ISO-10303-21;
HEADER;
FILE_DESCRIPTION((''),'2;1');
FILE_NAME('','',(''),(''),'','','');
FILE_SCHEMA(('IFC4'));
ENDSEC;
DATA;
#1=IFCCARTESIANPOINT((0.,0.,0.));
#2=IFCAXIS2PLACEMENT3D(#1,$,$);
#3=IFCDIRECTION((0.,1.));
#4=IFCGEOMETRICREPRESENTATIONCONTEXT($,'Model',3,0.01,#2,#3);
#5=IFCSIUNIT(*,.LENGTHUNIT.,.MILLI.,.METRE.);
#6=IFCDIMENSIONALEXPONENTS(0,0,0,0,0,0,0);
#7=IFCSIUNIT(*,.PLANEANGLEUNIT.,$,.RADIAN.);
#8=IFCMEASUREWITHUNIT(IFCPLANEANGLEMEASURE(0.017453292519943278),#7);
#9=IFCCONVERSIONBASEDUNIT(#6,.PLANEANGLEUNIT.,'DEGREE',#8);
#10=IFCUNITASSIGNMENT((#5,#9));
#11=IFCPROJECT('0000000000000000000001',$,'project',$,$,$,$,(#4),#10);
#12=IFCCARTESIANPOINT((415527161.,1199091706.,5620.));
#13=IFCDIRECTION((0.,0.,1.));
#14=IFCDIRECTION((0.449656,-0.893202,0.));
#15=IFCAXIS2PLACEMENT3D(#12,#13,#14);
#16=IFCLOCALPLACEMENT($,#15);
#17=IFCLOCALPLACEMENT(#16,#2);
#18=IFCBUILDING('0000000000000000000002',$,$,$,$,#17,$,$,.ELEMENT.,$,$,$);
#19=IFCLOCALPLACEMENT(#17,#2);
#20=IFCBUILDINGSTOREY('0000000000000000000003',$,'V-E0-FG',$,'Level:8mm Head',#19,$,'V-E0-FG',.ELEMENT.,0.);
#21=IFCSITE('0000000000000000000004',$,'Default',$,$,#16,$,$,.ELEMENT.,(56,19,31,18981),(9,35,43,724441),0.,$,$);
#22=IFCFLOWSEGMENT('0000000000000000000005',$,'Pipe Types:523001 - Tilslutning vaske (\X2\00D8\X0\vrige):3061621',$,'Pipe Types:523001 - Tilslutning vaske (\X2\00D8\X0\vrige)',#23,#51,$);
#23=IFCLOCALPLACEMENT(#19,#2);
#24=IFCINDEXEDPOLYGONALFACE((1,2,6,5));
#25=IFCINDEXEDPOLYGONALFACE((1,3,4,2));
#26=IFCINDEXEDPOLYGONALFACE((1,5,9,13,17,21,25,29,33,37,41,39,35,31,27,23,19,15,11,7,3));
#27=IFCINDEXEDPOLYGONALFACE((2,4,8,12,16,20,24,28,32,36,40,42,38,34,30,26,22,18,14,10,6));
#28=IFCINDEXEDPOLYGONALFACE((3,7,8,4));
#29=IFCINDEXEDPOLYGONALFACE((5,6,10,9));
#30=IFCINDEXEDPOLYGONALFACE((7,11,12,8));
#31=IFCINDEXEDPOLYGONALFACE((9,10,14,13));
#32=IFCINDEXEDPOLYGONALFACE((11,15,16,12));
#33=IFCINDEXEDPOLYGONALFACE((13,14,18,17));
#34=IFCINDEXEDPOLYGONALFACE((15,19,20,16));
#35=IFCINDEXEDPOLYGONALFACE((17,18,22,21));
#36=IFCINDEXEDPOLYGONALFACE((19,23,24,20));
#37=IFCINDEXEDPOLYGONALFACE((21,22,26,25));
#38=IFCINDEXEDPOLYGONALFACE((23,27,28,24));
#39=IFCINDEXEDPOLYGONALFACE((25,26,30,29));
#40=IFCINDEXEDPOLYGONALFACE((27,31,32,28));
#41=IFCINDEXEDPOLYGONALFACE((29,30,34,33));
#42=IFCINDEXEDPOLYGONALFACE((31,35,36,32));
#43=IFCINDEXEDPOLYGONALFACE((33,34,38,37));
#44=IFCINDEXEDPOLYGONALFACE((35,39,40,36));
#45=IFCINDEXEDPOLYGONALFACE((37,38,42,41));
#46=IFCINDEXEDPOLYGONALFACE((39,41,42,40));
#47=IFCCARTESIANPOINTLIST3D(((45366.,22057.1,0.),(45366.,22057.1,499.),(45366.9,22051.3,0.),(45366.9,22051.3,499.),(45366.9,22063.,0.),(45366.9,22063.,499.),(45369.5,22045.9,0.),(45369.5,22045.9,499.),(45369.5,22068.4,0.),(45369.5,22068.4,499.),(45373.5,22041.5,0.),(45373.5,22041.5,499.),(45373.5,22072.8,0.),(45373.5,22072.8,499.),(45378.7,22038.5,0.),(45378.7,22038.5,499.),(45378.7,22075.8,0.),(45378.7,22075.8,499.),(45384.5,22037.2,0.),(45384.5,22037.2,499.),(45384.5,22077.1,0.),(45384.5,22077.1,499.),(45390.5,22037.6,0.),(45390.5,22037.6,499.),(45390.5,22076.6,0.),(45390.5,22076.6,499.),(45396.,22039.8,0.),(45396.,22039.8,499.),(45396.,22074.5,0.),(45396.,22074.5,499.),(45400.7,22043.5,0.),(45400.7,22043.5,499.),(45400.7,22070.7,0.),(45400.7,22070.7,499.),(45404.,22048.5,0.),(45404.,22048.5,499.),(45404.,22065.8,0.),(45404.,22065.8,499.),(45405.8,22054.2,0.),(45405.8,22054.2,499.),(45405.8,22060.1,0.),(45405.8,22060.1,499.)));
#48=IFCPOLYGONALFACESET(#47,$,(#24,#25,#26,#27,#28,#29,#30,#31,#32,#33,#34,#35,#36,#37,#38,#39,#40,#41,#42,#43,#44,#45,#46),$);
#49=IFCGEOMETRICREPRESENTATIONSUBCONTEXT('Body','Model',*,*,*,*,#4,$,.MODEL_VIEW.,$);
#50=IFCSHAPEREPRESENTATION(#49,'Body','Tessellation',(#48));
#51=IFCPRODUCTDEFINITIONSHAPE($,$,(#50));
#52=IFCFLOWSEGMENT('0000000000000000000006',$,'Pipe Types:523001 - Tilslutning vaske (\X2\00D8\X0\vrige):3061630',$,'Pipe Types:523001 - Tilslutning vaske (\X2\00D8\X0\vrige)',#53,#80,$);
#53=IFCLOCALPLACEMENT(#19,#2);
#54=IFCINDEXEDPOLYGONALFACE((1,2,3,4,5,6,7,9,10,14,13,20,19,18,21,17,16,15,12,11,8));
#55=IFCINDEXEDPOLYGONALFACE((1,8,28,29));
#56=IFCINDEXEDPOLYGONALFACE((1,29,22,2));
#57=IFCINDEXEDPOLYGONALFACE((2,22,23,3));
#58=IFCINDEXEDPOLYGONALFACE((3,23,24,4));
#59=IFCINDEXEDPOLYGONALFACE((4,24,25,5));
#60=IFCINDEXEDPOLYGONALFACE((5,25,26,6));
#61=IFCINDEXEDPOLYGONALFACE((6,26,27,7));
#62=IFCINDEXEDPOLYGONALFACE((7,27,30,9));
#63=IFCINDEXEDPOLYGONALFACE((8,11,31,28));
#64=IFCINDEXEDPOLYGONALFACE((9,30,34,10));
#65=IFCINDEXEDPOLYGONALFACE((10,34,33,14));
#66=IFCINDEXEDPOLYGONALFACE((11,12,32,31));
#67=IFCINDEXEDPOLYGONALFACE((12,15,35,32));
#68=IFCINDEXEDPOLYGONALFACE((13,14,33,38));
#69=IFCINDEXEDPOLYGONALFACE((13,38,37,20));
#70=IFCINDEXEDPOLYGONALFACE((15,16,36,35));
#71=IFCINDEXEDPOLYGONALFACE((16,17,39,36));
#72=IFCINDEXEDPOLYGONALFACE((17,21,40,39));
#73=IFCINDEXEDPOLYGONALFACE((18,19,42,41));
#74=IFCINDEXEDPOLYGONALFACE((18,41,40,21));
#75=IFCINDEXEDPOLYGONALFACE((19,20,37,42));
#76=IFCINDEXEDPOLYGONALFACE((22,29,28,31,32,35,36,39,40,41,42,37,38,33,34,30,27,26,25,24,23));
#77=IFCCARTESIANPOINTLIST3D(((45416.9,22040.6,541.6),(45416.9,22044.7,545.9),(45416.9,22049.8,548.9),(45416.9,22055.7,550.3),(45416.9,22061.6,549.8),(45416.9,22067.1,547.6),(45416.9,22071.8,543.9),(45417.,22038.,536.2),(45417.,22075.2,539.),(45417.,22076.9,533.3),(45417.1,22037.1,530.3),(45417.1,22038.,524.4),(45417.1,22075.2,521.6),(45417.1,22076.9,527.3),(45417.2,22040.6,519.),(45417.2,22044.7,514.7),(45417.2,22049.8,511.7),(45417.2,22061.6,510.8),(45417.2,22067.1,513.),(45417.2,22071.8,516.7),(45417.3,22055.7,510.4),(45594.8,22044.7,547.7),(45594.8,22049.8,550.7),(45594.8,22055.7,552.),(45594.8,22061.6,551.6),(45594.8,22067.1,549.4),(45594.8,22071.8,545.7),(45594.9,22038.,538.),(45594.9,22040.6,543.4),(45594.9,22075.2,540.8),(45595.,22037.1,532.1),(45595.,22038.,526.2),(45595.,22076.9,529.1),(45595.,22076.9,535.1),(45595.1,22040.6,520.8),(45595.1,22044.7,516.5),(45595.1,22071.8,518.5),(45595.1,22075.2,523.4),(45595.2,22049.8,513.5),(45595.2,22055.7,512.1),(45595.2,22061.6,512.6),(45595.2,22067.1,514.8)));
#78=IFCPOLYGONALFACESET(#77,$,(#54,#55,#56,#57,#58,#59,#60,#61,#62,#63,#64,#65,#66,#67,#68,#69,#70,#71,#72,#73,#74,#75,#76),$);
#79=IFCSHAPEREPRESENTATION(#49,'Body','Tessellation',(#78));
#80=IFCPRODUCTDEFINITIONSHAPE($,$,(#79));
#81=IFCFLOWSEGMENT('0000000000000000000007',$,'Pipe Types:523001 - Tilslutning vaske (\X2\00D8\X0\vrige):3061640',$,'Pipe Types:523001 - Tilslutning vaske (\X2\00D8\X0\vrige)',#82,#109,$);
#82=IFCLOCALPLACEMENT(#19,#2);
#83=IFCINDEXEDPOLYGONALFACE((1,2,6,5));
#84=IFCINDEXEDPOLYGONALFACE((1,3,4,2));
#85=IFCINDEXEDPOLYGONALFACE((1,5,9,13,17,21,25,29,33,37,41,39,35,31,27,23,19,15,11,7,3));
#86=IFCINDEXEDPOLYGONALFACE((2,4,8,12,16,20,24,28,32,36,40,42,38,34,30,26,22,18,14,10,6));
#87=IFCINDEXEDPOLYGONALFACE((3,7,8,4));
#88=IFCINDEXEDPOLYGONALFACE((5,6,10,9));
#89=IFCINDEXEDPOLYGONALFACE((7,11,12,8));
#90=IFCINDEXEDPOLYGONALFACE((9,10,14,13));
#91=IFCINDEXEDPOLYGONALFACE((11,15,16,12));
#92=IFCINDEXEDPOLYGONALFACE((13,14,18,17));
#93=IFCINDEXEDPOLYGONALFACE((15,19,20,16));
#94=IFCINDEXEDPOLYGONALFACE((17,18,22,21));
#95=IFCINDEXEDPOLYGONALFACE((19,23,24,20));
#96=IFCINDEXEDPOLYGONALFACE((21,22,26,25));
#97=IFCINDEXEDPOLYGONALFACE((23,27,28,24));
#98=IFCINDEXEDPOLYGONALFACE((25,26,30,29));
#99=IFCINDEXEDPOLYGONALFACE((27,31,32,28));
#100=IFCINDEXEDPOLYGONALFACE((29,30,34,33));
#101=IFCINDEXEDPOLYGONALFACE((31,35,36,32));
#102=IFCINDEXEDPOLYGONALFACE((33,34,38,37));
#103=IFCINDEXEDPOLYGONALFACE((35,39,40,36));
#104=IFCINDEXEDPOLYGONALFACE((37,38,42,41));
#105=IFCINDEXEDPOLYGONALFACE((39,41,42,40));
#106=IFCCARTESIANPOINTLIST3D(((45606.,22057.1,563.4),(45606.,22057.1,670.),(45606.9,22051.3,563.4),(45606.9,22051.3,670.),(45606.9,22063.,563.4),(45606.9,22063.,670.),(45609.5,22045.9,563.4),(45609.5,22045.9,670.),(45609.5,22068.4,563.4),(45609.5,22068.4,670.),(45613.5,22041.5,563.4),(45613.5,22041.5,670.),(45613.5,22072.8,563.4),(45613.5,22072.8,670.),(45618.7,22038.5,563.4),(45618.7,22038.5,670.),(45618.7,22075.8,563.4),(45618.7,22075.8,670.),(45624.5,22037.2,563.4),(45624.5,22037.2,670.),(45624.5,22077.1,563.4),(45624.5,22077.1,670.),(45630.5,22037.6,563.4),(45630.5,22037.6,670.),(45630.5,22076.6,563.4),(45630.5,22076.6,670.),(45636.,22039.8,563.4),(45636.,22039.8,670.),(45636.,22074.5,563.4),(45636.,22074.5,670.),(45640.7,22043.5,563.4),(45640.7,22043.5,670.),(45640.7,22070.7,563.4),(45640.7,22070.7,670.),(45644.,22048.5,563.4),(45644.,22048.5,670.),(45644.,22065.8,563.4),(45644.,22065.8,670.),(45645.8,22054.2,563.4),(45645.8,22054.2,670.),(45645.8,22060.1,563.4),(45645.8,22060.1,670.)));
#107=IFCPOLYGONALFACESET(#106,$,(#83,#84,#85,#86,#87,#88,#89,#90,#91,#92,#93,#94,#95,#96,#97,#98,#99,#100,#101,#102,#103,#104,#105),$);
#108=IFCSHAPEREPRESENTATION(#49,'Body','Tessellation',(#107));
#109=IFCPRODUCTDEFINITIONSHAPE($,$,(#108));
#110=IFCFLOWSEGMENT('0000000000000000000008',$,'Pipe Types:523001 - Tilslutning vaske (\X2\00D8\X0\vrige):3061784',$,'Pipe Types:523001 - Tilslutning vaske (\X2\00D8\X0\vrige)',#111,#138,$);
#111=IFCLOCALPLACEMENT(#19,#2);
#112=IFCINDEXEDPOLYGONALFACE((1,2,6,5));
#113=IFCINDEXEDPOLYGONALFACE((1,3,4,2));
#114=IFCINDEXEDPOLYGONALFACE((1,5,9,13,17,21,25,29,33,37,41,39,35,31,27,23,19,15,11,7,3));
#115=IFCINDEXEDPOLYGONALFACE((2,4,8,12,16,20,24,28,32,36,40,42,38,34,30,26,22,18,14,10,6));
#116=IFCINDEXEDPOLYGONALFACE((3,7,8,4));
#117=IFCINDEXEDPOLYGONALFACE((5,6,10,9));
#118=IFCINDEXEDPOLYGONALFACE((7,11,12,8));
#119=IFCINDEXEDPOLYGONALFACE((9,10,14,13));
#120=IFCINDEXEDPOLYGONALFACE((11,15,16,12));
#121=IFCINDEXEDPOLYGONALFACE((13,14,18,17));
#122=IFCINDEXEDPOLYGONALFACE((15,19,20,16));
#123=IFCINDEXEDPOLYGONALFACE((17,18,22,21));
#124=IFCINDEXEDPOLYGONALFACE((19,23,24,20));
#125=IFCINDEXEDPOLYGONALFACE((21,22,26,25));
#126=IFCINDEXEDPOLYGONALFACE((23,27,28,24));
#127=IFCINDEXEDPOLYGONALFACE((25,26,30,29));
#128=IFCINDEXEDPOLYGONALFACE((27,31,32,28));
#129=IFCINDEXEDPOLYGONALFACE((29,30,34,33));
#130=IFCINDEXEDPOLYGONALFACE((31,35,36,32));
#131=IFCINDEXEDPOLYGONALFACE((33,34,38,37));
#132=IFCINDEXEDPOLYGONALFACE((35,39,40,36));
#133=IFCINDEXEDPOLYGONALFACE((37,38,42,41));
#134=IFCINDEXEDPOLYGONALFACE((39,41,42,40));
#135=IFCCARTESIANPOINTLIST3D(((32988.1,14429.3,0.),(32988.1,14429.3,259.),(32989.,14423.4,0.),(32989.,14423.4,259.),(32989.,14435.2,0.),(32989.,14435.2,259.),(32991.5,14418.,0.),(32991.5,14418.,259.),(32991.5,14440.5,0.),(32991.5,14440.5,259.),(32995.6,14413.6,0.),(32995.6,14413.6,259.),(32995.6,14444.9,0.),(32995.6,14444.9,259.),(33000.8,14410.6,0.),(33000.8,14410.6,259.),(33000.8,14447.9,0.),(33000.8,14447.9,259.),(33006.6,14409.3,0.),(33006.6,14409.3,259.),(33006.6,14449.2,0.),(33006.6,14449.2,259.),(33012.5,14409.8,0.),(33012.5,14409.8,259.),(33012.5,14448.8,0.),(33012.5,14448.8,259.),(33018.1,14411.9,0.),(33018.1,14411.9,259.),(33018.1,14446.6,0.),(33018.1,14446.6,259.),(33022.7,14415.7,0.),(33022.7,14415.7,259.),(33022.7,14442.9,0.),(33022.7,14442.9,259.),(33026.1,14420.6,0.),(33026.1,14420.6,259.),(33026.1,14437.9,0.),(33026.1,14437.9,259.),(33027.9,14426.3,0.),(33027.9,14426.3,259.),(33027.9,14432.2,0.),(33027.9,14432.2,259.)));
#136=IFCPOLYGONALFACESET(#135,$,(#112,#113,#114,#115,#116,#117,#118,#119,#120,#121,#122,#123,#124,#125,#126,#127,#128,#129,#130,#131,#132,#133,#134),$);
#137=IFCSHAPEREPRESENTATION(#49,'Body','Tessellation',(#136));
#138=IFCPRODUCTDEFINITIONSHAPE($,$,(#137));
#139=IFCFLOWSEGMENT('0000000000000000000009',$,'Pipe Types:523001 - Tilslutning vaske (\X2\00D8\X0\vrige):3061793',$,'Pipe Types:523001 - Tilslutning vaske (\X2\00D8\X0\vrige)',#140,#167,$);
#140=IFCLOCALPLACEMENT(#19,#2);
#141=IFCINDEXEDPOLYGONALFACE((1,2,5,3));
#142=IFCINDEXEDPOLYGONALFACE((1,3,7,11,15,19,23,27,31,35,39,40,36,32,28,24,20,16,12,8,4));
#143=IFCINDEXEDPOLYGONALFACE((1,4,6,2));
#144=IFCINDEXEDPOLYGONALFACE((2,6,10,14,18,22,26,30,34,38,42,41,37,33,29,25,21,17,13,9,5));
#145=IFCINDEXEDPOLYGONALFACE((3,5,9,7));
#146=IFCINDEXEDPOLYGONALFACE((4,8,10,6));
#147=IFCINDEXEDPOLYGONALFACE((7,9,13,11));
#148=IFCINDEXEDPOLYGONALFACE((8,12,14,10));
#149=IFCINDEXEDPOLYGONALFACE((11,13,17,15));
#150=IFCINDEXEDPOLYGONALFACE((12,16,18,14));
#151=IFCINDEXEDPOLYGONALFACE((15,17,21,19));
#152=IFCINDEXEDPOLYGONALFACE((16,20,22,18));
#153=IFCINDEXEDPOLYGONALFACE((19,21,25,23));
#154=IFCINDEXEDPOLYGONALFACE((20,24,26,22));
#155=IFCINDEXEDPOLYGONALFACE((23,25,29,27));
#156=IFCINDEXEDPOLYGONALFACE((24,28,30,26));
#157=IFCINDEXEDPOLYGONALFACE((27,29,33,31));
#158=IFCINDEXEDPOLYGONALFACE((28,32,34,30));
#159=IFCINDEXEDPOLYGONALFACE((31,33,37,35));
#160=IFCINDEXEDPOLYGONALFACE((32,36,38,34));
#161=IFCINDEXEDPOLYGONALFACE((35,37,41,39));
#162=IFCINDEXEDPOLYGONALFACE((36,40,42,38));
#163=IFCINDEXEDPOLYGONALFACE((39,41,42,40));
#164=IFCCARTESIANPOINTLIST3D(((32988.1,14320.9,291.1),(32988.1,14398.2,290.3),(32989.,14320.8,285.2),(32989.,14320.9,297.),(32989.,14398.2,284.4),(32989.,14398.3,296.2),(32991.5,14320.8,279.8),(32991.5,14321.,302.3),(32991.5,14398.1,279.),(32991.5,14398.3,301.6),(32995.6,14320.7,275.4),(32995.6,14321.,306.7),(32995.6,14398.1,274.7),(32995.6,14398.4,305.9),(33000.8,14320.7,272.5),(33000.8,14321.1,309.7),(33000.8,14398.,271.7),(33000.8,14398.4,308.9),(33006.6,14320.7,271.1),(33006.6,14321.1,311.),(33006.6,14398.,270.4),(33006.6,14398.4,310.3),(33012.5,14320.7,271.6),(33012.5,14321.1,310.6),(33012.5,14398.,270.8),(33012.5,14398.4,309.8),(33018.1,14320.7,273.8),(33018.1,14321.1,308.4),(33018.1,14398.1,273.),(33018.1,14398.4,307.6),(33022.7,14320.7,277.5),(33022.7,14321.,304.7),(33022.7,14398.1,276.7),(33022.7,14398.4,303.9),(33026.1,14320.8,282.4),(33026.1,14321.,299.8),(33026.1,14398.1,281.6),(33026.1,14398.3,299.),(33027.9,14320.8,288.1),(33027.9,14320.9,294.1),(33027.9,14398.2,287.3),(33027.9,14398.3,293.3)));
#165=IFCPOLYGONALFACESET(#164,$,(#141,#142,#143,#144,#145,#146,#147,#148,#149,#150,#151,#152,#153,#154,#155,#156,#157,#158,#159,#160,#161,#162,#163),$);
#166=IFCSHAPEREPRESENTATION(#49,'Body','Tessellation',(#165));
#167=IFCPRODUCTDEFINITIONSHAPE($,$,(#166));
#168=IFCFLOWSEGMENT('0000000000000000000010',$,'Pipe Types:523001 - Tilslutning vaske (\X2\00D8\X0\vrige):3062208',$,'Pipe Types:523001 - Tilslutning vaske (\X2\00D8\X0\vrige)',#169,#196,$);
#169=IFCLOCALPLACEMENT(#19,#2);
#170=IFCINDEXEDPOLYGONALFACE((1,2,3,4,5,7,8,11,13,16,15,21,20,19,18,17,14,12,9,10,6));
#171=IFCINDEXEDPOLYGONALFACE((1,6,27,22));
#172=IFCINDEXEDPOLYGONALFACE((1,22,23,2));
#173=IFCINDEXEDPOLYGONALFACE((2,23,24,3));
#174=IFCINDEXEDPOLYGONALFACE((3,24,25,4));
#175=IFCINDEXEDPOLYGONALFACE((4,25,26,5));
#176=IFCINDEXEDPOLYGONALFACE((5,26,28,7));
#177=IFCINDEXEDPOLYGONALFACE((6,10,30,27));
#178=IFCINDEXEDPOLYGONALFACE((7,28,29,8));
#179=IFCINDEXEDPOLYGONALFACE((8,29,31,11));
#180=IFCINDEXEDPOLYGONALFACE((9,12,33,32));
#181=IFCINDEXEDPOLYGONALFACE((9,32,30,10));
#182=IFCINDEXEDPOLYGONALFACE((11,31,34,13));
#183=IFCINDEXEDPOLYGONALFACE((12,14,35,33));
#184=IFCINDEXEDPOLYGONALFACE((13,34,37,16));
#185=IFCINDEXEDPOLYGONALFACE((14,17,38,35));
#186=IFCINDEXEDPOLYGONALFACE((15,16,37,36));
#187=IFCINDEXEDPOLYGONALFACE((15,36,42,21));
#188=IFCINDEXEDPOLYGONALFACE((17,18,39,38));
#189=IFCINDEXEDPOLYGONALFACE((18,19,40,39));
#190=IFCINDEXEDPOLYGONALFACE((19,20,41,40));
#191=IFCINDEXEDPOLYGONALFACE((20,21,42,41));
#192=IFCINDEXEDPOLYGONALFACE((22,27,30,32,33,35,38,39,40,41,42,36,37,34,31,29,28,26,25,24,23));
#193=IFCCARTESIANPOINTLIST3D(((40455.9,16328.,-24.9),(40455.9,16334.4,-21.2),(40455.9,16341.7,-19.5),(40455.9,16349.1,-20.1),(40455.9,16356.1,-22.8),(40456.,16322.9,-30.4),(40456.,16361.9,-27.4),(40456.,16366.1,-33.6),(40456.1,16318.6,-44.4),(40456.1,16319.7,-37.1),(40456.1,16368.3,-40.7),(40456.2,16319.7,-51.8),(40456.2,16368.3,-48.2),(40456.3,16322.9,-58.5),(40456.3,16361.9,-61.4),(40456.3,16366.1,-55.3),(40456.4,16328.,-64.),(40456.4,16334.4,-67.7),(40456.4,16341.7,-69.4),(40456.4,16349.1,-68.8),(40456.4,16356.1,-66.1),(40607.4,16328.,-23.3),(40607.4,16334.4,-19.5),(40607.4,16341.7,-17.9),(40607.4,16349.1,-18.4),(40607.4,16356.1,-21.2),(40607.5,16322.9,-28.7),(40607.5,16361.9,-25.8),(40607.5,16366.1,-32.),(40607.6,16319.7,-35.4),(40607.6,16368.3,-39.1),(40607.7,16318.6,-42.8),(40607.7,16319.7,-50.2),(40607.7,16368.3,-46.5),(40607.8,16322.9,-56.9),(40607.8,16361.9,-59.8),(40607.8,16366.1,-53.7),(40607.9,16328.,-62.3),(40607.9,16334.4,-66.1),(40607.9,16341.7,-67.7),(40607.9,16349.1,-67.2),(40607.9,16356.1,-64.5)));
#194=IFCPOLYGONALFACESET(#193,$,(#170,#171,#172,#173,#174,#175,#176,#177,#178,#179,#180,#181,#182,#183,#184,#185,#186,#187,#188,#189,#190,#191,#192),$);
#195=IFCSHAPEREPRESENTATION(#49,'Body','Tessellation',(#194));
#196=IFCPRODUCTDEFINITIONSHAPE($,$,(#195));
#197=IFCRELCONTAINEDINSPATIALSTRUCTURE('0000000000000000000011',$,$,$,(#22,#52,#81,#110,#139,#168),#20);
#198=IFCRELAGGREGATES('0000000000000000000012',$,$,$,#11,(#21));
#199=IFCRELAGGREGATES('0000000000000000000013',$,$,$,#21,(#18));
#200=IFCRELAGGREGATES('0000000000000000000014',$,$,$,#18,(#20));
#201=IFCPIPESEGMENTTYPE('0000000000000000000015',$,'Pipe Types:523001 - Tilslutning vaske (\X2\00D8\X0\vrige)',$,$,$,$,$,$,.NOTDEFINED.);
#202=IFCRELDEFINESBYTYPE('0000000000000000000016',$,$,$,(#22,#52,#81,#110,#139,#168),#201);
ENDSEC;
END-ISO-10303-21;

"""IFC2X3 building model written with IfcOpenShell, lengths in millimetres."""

from ifc_helpers import new_model, entity, si_unit, converted_unit, direction, frame, frame_2d, origin, origin_2d_with_axis, place, context, subcontext, project, spatial, circle, extrude, type_object, element, save


model = new_model("IFC2X3")

# Units and contexts
model_context = context("Model", 3, precision=0.01, world=origin(), true_north=direction((0.0, 1.0)))
body_context = subcontext(model_context, "Body", "Model", "MODEL_VIEW")
ifc_project = project(units=[si_unit("LENGTHUNIT", "METRE", prefix="MILLI"), converted_unit("PLANEANGLEUNIT", "DEGREE", entity("IfcPlaneAngleMeasure", 0.017453292519943278), si_unit("PLANEANGLEUNIT", "RADIAN"), dimensions=[0, 0, 0, 0, 0, 0, 0])], contexts=[model_context])

# Site, building, storey
site_placement = place(None, frame((415527161.0, 1199091706.0, 5620.0), z_axis=(0.0, 0.0, 1.0), x_axis=(0.449656, -0.893202, 0.0)))
site = spatial("IfcSite", under=ifc_project, at=site_placement, Name="Default", CompositionType="ELEMENT", RefLatitude=(56, 19, 31, 18981), RefLongitude=(9, 35, 43, 724441), RefElevation=0.0)
building_placement = place(site_placement, origin())
building = spatial("IfcBuilding", under=site, at=building_placement, CompositionType="ELEMENT")
storey_placement = place(building_placement, origin())
storey = spatial("IfcBuildingStorey", under=building, at=storey_placement, Name="V-E0-FG", ObjectType="Level:8mm Head", LongName="V-E0-FG", CompositionType="ELEMENT", Elevation=0.0)

# Flow segments
pipe_segment_type_1 = type_object("IfcPipeSegmentType", Name="Pipe Types:523001 - Tilslutning vaske (Øvrige)", PredefinedType="NOTDEFINED")
flow_segment_1_placement = place(storey_placement, origin())
element("IfcFlowSegment", 1, at=flow_segment_1_placement, inside=storey, type_object=pipe_segment_type_1, Name="Pipe Types:523001 - Tilslutning vaske (Øvrige):3061621", ObjectType="Pipe Types:523001 - Tilslutning vaske (Øvrige)", context=body_context, shape_type="SweptSolid", body=[
    extrude(circle(Radius=20.0, at=origin_2d_with_axis()), frame((45386.0, 22057.1, 0.0), z_axis=(0.0, 0.0, 1.0), x_axis=(-1.0, 0.0, 0.0)), (0.0, 0.0, 1.0), 499.0),
])
flow_segment_2_placement = place(storey_placement, origin())
element("IfcFlowSegment", 2, at=flow_segment_2_placement, inside=storey, type_object=pipe_segment_type_1, Name="Pipe Types:523001 - Tilslutning vaske (Øvrige):3061630", ObjectType="Pipe Types:523001 - Tilslutning vaske (Øvrige)", context=body_context, shape_type="SweptSolid", body=[
    extrude(circle(Radius=20.0, at=frame_2d((0.0, 0.0), x_axis=(1.0, 0.0))), frame((45417.1, 22057.1, 530.3), z_axis=(0.99995, 0.0, 0.01), x_axis=(0.0, -1.0, 0.0)), (0.0, 0.0, 1.0), 177.9),
])
flow_segment_3_placement = place(storey_placement, origin())
element("IfcFlowSegment", 3, at=flow_segment_3_placement, inside=storey, type_object=pipe_segment_type_1, Name="Pipe Types:523001 - Tilslutning vaske (Øvrige):3061640", ObjectType="Pipe Types:523001 - Tilslutning vaske (Øvrige)", context=body_context, shape_type="SweptSolid", body=[
    extrude(circle(Radius=20.0, at=origin_2d_with_axis()), frame((45626.0, 22057.1, 563.4), z_axis=(0.0, 0.0, 1.0), x_axis=(-1.0, 0.0, 0.0)), (0.0, 0.0, 1.0), 106.6),
])
flow_segment_4_placement = place(storey_placement, origin())
element("IfcFlowSegment", 4, at=flow_segment_4_placement, inside=storey, type_object=pipe_segment_type_1, Name="Pipe Types:523001 - Tilslutning vaske (Øvrige):3061784", ObjectType="Pipe Types:523001 - Tilslutning vaske (Øvrige)", context=body_context, shape_type="SweptSolid", body=[
    extrude(circle(Radius=20.0, at=frame_2d((0.0, 0.0), x_axis=(1.0, 0.0))), frame((33008.1, 14429.3, 0.0), z_axis=(0.0, 0.0, 1.0), x_axis=(-1.0, 0.0, 0.0)), (0.0, 0.0, 1.0), 259.0),
])
flow_segment_5_placement = place(storey_placement, origin())
element("IfcFlowSegment", 5, at=flow_segment_5_placement, inside=storey, type_object=pipe_segment_type_1, Name="Pipe Types:523001 - Tilslutning vaske (Øvrige):3061793", ObjectType="Pipe Types:523001 - Tilslutning vaske (Øvrige)", context=body_context, shape_type="SweptSolid", body=[
    extrude(circle(Radius=20.0, at=frame_2d((0.0, 0.0), x_axis=(1.0, 0.0))), frame((33008.1, 14320.9, 291.1), z_axis=(0.0, 0.99995, -0.01), x_axis=(-1.0, 0.0, 0.0)), (0.0, 0.0, 1.0), 77.4),
])
flow_segment_6_placement = place(storey_placement, origin())
element("IfcFlowSegment", 6, at=flow_segment_6_placement, inside=storey, type_object=pipe_segment_type_1, Name="Pipe Types:523001 - Tilslutning vaske (Øvrige):3062208", ObjectType="Pipe Types:523001 - Tilslutning vaske (Øvrige)", context=body_context, shape_type="SweptSolid", body=[
    extrude(circle(Radius=25.0, at=frame_2d((0.0, 0.0), x_axis=(1.0, 0.0))), frame((40456.1, 16343.6, -44.4), z_axis=(0.999941, 0.0, 0.010824), x_axis=(0.0, -1.0, 0.0)), (0.0, 0.0, 1.0), 151.5),
])

save(model, "model.ifc")
